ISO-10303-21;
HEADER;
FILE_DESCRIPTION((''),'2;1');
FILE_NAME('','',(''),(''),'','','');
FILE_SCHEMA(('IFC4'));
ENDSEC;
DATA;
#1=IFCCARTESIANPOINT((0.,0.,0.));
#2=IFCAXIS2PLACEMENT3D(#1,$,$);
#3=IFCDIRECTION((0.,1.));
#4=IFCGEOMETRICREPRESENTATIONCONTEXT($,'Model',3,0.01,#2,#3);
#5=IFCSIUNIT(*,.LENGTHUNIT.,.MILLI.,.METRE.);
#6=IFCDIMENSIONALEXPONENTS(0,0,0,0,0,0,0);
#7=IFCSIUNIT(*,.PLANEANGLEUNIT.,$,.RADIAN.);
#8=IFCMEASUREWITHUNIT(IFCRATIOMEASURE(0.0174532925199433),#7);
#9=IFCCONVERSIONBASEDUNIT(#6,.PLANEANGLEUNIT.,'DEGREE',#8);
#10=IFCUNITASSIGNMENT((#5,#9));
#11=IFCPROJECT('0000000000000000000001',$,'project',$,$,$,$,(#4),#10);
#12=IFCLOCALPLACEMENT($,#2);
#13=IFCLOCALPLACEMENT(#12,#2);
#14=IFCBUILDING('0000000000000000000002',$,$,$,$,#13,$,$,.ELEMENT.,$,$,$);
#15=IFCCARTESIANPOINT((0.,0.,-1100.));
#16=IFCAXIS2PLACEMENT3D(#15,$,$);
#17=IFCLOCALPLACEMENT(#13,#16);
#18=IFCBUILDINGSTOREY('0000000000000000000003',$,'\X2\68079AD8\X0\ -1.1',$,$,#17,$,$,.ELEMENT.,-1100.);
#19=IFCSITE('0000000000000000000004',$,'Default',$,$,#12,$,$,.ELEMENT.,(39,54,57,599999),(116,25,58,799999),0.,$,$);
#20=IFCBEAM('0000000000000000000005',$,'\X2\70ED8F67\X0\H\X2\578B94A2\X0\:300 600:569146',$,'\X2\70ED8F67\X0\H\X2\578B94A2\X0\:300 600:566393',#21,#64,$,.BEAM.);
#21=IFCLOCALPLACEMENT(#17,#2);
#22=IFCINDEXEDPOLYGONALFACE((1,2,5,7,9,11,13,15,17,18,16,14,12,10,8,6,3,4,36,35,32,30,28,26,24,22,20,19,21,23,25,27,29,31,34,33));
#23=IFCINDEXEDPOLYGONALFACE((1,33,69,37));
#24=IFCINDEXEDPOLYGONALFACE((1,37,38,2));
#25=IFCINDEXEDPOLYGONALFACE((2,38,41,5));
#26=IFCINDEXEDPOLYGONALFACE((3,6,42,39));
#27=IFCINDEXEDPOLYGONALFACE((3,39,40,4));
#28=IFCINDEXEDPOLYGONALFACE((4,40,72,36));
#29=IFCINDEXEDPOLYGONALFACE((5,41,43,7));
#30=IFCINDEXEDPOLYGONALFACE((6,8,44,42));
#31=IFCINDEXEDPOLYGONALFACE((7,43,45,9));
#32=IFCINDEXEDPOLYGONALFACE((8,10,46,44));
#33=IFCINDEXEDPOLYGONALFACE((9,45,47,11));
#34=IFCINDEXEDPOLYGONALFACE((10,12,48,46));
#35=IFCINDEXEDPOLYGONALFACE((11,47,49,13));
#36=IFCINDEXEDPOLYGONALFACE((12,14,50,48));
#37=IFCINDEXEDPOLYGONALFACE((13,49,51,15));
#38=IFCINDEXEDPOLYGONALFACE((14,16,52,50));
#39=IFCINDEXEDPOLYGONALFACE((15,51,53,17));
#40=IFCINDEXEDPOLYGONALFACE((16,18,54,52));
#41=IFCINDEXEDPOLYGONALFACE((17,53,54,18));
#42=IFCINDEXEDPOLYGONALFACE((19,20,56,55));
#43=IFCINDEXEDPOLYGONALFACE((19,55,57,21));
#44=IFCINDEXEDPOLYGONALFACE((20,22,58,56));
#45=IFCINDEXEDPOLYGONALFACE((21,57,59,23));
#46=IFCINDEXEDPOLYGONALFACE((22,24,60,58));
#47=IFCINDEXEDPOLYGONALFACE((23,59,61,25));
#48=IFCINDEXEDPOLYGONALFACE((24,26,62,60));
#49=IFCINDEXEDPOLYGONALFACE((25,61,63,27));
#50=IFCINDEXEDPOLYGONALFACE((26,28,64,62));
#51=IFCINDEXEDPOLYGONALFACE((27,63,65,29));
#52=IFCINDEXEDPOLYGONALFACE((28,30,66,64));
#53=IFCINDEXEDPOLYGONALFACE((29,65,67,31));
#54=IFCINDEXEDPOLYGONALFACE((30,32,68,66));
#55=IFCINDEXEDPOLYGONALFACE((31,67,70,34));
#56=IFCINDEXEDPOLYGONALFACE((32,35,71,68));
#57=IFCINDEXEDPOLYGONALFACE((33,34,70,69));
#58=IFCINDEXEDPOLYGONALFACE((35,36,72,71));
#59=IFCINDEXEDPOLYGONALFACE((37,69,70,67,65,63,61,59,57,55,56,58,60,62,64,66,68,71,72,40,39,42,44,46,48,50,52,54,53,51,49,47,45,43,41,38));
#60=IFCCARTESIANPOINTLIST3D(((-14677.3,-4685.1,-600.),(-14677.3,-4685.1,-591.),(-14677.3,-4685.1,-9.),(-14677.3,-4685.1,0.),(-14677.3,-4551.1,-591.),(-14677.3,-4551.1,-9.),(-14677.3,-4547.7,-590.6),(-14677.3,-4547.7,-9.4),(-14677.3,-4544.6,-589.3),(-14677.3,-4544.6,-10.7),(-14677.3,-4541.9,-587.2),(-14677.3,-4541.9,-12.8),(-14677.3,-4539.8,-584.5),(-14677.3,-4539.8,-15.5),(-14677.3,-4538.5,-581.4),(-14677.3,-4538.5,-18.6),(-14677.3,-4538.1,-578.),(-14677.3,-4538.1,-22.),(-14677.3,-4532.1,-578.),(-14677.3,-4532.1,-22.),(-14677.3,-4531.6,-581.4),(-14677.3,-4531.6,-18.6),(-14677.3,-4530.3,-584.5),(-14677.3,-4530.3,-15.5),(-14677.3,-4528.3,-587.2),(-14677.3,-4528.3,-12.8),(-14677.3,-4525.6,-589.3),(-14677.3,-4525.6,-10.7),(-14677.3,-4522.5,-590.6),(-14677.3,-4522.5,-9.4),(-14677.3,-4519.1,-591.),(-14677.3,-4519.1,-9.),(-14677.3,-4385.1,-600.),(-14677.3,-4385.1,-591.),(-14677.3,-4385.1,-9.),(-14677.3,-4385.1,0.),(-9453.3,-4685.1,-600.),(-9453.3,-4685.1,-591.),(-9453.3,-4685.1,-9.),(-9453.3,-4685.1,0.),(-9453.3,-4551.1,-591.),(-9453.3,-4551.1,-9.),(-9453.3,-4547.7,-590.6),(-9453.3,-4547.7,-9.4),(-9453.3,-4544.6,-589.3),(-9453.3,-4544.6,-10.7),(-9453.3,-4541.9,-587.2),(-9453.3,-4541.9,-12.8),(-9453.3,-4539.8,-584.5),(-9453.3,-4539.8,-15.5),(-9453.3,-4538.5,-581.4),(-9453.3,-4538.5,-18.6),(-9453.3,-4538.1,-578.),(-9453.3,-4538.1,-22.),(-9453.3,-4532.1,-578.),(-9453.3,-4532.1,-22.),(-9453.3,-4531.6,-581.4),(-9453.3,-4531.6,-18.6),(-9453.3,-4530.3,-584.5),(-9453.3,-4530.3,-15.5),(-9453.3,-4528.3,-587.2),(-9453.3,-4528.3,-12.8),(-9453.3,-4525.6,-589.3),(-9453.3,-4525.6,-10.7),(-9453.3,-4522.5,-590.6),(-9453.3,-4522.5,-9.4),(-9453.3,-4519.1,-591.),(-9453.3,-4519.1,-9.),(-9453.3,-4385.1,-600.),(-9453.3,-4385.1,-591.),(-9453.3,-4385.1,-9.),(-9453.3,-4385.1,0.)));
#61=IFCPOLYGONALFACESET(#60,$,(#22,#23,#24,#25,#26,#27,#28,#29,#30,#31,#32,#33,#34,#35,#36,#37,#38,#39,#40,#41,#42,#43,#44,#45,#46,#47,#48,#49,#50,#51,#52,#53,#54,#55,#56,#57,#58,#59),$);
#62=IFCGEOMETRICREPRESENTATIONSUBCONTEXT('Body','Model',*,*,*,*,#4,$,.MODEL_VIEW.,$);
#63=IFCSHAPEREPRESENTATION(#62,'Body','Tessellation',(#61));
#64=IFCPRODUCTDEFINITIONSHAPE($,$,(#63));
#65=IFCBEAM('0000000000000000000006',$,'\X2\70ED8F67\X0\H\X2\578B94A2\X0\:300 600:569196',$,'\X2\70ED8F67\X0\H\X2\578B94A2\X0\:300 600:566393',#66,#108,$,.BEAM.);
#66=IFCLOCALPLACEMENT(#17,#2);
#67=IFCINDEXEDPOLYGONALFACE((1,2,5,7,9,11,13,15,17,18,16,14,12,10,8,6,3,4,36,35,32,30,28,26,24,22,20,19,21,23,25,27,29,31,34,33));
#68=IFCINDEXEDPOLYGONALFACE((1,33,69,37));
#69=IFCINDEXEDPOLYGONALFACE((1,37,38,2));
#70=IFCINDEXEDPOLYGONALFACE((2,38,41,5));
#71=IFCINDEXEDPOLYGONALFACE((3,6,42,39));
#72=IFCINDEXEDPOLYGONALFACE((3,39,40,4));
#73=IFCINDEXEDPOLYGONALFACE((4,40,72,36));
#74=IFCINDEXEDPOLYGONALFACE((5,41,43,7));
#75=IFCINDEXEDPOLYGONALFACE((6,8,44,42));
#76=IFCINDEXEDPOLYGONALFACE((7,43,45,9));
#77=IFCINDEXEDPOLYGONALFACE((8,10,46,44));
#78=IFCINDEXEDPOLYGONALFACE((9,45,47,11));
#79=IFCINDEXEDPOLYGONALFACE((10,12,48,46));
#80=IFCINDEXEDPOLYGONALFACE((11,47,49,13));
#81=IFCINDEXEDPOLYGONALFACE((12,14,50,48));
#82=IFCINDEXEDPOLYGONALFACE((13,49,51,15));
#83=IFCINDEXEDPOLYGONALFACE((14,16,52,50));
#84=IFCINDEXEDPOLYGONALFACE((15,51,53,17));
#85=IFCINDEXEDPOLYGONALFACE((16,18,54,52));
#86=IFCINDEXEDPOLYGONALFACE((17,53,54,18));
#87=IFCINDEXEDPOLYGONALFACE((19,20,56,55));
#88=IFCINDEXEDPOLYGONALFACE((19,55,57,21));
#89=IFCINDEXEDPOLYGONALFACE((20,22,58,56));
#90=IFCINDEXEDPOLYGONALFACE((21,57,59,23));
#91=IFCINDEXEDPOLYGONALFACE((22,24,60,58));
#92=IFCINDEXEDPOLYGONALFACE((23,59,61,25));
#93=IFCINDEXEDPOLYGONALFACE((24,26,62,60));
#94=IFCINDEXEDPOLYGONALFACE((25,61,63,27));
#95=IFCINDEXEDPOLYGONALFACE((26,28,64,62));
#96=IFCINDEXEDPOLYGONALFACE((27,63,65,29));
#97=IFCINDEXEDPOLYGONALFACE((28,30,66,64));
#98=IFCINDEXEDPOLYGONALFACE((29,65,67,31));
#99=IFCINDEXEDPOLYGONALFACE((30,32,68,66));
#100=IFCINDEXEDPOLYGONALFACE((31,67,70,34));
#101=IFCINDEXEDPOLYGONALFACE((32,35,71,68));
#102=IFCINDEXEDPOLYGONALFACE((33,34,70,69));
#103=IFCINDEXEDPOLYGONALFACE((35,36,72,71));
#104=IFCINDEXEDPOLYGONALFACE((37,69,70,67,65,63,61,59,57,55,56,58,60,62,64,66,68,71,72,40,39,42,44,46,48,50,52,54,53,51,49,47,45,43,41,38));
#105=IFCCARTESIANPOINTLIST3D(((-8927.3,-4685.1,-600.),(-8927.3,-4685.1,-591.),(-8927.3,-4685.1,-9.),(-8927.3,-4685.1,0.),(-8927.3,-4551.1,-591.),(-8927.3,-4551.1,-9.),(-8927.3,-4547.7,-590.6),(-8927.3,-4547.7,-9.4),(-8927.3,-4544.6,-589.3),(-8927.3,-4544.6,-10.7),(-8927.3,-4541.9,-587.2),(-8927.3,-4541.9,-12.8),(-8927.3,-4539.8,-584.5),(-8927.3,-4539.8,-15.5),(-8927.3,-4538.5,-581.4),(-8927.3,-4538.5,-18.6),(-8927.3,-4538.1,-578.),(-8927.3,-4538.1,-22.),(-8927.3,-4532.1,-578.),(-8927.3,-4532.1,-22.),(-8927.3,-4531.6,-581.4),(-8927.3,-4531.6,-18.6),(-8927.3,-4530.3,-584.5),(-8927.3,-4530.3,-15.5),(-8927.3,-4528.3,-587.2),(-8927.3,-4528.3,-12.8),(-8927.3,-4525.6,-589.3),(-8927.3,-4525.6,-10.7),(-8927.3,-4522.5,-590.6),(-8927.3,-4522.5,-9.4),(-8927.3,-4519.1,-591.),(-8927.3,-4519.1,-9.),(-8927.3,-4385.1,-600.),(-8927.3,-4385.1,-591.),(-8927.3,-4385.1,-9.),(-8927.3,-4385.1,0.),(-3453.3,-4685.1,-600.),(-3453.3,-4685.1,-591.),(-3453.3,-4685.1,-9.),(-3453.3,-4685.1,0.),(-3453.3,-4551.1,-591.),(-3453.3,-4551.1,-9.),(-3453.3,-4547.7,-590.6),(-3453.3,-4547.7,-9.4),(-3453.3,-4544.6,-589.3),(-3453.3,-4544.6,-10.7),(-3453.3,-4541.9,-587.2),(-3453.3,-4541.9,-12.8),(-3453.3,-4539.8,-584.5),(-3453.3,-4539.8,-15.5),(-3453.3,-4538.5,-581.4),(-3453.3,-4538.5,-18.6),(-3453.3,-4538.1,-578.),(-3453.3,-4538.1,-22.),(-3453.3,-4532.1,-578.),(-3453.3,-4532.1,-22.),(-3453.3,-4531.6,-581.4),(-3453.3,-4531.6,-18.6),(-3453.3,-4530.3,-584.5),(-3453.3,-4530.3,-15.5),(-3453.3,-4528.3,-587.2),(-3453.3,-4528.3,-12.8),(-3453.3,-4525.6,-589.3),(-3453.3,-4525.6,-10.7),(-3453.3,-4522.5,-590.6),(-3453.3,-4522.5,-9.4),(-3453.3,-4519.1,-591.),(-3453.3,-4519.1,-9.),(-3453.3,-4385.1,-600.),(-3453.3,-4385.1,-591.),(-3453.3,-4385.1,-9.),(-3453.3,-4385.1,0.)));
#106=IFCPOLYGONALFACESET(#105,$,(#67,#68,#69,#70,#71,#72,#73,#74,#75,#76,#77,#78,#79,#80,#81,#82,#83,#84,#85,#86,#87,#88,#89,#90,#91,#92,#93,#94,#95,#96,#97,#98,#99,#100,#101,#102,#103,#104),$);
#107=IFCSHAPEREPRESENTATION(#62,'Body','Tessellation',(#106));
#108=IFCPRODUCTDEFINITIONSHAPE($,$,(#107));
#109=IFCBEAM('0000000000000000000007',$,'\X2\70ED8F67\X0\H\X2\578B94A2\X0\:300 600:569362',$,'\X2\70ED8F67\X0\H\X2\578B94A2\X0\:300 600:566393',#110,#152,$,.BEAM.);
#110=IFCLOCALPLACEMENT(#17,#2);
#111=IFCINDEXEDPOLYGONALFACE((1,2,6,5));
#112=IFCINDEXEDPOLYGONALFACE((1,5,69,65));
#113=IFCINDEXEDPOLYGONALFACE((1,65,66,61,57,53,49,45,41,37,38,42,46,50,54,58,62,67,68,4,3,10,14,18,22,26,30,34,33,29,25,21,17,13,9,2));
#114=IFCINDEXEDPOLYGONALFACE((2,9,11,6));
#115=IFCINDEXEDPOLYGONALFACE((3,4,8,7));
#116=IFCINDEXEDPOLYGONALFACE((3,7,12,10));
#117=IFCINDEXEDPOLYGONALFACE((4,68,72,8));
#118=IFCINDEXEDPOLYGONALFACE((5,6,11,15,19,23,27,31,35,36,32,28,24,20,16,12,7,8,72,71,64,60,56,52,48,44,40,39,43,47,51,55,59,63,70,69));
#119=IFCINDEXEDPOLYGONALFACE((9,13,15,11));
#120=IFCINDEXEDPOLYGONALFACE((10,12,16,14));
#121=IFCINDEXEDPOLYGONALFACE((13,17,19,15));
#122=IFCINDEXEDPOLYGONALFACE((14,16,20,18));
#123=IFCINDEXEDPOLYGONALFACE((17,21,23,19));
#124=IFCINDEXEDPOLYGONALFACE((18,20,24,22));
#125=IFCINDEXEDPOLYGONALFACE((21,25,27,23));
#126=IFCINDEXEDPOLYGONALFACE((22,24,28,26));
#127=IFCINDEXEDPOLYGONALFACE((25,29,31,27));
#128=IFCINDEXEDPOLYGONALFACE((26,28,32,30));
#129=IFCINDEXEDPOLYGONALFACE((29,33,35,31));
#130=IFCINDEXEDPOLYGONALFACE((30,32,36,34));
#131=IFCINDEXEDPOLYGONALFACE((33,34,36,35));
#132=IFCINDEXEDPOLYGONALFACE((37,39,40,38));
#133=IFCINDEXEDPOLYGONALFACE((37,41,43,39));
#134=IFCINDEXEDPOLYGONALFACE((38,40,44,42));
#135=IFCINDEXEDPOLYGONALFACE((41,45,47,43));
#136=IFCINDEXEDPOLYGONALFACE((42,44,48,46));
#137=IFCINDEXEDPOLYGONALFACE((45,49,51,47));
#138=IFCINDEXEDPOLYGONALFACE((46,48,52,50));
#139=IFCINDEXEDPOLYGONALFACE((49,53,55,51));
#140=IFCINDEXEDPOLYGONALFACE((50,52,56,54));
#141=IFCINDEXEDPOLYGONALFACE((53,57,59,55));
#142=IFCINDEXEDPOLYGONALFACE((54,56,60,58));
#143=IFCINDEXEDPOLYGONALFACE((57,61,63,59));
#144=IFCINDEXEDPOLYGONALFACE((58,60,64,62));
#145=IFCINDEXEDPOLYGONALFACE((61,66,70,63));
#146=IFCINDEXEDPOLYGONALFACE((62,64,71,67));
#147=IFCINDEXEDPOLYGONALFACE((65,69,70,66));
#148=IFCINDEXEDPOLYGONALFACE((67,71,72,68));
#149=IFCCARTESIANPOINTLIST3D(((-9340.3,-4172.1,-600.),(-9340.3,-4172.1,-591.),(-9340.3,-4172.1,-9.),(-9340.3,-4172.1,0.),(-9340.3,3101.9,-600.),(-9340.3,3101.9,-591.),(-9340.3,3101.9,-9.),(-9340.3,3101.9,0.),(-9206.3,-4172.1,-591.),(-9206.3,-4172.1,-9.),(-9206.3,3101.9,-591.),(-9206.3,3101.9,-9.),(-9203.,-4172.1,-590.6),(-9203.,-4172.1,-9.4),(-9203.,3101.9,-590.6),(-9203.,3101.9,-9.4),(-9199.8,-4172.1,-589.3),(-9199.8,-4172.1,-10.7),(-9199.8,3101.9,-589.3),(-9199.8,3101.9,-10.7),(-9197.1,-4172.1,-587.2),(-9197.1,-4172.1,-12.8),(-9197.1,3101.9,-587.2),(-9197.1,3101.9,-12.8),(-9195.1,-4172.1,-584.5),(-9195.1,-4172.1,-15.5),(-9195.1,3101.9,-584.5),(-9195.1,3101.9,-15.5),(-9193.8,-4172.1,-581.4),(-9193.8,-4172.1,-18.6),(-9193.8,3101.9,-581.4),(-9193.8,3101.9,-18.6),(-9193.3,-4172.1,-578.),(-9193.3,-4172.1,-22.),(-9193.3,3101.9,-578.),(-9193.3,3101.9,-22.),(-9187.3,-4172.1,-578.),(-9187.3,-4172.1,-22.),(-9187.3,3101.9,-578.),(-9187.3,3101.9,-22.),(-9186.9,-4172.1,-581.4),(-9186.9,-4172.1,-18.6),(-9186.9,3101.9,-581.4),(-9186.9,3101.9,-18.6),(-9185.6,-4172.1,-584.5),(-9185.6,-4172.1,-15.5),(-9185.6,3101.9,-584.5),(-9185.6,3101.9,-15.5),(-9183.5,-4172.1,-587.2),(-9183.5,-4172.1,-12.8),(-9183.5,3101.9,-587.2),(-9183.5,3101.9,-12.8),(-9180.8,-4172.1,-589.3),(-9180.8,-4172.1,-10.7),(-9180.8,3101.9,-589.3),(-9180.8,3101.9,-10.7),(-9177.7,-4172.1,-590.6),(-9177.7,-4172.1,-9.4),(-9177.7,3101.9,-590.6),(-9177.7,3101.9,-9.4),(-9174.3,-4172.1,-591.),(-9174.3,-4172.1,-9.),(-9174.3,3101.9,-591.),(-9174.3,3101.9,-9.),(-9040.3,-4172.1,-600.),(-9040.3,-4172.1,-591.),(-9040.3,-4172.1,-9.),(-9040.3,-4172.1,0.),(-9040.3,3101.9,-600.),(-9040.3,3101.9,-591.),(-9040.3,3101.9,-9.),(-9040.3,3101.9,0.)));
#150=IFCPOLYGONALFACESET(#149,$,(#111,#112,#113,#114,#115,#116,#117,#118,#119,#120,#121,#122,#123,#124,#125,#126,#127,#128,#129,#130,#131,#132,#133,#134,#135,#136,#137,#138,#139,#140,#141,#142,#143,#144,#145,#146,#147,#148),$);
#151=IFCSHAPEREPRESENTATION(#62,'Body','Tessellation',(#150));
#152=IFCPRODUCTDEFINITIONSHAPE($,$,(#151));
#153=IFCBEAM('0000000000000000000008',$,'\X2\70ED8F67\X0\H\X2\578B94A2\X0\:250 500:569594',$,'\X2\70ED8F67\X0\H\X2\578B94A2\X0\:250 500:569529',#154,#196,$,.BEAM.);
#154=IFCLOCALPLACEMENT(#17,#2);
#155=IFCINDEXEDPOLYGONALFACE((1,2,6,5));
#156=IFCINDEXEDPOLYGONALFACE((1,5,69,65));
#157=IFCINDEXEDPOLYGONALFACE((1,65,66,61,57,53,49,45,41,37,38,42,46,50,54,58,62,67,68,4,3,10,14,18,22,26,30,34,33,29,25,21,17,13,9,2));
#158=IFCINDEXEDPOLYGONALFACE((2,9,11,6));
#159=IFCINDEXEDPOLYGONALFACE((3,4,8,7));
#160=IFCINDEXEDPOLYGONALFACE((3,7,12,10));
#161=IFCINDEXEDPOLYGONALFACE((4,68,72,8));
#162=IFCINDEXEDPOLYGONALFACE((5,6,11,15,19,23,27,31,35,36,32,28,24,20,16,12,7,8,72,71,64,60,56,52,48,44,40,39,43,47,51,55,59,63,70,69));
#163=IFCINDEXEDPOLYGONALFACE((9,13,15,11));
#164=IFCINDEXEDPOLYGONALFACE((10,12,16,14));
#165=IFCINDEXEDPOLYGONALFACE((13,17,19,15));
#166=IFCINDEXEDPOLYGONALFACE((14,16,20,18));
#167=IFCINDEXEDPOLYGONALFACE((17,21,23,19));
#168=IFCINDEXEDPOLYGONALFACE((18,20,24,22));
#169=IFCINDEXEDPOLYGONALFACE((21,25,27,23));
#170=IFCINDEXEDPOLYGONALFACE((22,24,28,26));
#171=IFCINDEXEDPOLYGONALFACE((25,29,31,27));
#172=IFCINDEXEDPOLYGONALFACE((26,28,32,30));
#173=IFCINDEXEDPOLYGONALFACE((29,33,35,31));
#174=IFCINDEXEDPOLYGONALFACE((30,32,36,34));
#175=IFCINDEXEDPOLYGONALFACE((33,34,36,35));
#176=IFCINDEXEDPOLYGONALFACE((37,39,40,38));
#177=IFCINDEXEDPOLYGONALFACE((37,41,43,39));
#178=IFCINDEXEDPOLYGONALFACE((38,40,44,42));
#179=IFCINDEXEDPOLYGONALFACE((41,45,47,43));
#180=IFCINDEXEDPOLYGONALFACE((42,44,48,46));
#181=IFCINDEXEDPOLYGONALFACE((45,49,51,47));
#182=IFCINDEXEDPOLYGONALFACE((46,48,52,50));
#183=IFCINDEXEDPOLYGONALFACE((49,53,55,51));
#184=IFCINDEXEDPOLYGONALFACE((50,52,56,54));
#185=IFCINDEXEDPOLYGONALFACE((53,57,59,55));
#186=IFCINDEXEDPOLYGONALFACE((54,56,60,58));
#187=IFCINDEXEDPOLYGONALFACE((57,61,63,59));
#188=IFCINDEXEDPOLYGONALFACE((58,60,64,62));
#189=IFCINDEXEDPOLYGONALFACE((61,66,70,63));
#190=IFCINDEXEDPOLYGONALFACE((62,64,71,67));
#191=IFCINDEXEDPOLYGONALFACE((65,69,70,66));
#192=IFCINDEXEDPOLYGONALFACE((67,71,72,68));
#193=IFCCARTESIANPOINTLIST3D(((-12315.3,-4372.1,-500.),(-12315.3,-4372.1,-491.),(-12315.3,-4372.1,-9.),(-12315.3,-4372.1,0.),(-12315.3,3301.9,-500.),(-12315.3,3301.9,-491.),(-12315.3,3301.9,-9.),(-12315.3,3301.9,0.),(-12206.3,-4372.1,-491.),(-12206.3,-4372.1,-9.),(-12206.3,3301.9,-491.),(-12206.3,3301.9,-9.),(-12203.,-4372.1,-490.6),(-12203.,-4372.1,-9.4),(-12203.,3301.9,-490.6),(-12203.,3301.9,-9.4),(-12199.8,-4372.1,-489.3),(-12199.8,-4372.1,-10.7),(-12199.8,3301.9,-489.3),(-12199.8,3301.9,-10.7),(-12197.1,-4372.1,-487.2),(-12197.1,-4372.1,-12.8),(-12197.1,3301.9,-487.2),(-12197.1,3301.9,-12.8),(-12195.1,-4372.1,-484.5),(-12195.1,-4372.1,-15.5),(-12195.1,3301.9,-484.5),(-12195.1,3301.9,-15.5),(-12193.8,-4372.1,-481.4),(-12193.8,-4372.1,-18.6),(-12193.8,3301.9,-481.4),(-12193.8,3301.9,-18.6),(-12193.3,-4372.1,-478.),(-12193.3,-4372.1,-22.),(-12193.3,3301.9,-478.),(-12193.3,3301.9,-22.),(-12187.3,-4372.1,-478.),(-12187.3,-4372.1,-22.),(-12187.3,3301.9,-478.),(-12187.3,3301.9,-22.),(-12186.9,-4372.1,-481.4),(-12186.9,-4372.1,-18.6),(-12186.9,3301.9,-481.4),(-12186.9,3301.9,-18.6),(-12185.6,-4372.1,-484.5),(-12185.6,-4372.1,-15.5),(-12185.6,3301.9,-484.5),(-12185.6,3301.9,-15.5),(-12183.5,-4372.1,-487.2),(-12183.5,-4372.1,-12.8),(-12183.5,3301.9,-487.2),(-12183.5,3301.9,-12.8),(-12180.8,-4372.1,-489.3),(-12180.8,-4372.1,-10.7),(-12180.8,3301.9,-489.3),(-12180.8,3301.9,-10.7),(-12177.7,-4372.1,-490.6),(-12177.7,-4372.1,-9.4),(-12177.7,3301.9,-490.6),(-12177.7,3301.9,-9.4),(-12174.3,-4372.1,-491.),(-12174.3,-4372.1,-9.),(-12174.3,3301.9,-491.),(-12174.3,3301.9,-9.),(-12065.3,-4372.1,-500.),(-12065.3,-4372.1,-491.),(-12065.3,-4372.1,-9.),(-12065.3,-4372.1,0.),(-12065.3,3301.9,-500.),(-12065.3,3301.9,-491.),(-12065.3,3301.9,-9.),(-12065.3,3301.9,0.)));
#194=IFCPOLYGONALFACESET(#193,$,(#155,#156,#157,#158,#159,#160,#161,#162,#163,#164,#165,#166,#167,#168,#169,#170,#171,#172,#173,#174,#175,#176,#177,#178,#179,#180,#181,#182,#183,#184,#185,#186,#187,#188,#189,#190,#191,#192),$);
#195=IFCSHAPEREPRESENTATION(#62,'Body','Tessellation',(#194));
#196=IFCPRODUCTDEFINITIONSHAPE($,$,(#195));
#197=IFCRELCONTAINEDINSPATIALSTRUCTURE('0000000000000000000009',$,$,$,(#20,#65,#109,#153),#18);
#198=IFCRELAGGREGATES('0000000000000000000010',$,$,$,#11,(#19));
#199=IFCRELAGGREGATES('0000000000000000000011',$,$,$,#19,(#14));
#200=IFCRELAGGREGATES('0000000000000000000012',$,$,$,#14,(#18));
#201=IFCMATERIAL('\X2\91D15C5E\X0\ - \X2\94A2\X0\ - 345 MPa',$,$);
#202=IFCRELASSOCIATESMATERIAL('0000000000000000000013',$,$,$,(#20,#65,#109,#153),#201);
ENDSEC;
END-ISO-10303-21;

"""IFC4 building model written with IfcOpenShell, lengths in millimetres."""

from ifc_helpers import new_model, entity, si_unit, converted_unit, direction, frame, frame_2d, origin, place, context, subcontext, project, spatial, i_section, extrude, material, element, save


model = new_model("IFC4")

# Units and contexts
model_context = context("Model", 3, precision=0.01, world=origin(), true_north=direction((0.0, 1.0)))
body_context = subcontext(model_context, "Body", "Model", "MODEL_VIEW")
ifc_project = project(units=[si_unit("LENGTHUNIT", "METRE", prefix="MILLI"), converted_unit("PLANEANGLEUNIT", "DEGREE", entity("IfcRatioMeasure", 0.0174532925199433), si_unit("PLANEANGLEUNIT", "RADIAN"), dimensions=[0, 0, 0, 0, 0, 0, 0])], contexts=[model_context])

# Site, building, storey
site_placement = place(None, origin())
site = spatial("IfcSite", under=ifc_project, at=site_placement, Name="Default", CompositionType="ELEMENT", RefLatitude=(39, 54, 57, 599999), RefLongitude=(116, 25, 58, 799999), RefElevation=0.0)
building_placement = place(site_placement, origin())
building = spatial("IfcBuilding", under=site, at=building_placement, CompositionType="ELEMENT")
storey_placement = place(building_placement, frame((0.0, 0.0, -1100.0)))
storey = spatial("IfcBuildingStorey", under=building, at=storey_placement, Name="标高 -1.1", CompositionType="ELEMENT", Elevation=-1100.0)

# Beams
ifc_material_1 = material(Name="金属 - 钢 - 345 MPa")
beam_1_placement = place(storey_placement, frame((-14690.3, -4535.1, 0.0)))
element("IfcBeam", 1, at=beam_1_placement, inside=storey, material=ifc_material_1, Name="热轧H型钢:300 600:569146", ObjectType="热轧H型钢:300 600:566393", PredefinedType="BEAM", context=body_context, shape_type="SweptSolid", body=[
    extrude(i_section(OverallWidth=300.0, OverallDepth=600.0, WebThickness=6.0, FlangeThickness=9.0, FilletRadius=13.0, at=frame_2d((0.0, 0.0), x_axis=(0.0, 1.0))), frame((13.0, 0.0, -300.0), z_axis=(1.0, 0.0, 0.0), x_axis=(0.0, 0.0, -1.0)), (0.0, 0.0, 1.0), 5224.0),
])
beam_2_placement = place(storey_placement, frame((-8940.3, -4535.1, 0.0)))
element("IfcBeam", 2, at=beam_2_placement, inside=storey, material=ifc_material_1, Name="热轧H型钢:300 600:569196", ObjectType="热轧H型钢:300 600:566393", PredefinedType="BEAM", context=body_context, shape_type="SweptSolid", body=[
    extrude(i_section(OverallWidth=300.0, OverallDepth=600.0, WebThickness=6.0, FlangeThickness=9.0, FilletRadius=13.0, at=frame_2d((0.0, 0.0), x_axis=(0.0, 1.0))), frame((13.0, 0.0, -300.0), z_axis=(1.0, 0.0, 0.0), x_axis=(0.0, 0.0, -1.0)), (0.0, 0.0, 1.0), 5474.0),
])
beam_3_placement = place(storey_placement, frame((-9190.3, -4185.1, 0.0), z_axis=(0.0, 0.0, 1.0), x_axis=(0.0, 1.0, 0.0)))
element("IfcBeam", 3, at=beam_3_placement, inside=storey, material=ifc_material_1, Name="热轧H型钢:300 600:569362", ObjectType="热轧H型钢:300 600:566393", PredefinedType="BEAM", context=body_context, shape_type="SweptSolid", body=[
    extrude(i_section(OverallWidth=300.0, OverallDepth=600.0, WebThickness=6.0, FlangeThickness=9.0, FilletRadius=13.0, at=frame_2d((0.0, 0.0), x_axis=(0.0, 1.0))), frame((13.0, 0.0, -300.0), z_axis=(1.0, 0.0, 0.0), x_axis=(0.0, 0.0, -1.0)), (0.0, 0.0, 1.0), 7274.0),
])
beam_4_placement = place(storey_placement, frame((-12190.3, -4535.1, 0.0), z_axis=(0.0, 0.0, 1.0), x_axis=(0.0, 1.0, 0.0)))
element("IfcBeam", 4, at=beam_4_placement, inside=storey, material=ifc_material_1, Name="热轧H型钢:250 500:569594", ObjectType="热轧H型钢:250 500:569529", PredefinedType="BEAM", context=body_context, shape_type="SweptSolid", body=[
    extrude(i_section(OverallWidth=250.0, OverallDepth=500.0, WebThickness=6.0, FlangeThickness=9.0, FilletRadius=13.0, at=frame_2d((0.0, 0.0), x_axis=(0.0, 1.0))), frame((163.0, 0.0, -250.0), z_axis=(1.0, 0.0, 0.0), x_axis=(0.0, 0.0, -1.0)), (0.0, 0.0, 1.0), 7674.0),
])

save(model, "model.ifc")
